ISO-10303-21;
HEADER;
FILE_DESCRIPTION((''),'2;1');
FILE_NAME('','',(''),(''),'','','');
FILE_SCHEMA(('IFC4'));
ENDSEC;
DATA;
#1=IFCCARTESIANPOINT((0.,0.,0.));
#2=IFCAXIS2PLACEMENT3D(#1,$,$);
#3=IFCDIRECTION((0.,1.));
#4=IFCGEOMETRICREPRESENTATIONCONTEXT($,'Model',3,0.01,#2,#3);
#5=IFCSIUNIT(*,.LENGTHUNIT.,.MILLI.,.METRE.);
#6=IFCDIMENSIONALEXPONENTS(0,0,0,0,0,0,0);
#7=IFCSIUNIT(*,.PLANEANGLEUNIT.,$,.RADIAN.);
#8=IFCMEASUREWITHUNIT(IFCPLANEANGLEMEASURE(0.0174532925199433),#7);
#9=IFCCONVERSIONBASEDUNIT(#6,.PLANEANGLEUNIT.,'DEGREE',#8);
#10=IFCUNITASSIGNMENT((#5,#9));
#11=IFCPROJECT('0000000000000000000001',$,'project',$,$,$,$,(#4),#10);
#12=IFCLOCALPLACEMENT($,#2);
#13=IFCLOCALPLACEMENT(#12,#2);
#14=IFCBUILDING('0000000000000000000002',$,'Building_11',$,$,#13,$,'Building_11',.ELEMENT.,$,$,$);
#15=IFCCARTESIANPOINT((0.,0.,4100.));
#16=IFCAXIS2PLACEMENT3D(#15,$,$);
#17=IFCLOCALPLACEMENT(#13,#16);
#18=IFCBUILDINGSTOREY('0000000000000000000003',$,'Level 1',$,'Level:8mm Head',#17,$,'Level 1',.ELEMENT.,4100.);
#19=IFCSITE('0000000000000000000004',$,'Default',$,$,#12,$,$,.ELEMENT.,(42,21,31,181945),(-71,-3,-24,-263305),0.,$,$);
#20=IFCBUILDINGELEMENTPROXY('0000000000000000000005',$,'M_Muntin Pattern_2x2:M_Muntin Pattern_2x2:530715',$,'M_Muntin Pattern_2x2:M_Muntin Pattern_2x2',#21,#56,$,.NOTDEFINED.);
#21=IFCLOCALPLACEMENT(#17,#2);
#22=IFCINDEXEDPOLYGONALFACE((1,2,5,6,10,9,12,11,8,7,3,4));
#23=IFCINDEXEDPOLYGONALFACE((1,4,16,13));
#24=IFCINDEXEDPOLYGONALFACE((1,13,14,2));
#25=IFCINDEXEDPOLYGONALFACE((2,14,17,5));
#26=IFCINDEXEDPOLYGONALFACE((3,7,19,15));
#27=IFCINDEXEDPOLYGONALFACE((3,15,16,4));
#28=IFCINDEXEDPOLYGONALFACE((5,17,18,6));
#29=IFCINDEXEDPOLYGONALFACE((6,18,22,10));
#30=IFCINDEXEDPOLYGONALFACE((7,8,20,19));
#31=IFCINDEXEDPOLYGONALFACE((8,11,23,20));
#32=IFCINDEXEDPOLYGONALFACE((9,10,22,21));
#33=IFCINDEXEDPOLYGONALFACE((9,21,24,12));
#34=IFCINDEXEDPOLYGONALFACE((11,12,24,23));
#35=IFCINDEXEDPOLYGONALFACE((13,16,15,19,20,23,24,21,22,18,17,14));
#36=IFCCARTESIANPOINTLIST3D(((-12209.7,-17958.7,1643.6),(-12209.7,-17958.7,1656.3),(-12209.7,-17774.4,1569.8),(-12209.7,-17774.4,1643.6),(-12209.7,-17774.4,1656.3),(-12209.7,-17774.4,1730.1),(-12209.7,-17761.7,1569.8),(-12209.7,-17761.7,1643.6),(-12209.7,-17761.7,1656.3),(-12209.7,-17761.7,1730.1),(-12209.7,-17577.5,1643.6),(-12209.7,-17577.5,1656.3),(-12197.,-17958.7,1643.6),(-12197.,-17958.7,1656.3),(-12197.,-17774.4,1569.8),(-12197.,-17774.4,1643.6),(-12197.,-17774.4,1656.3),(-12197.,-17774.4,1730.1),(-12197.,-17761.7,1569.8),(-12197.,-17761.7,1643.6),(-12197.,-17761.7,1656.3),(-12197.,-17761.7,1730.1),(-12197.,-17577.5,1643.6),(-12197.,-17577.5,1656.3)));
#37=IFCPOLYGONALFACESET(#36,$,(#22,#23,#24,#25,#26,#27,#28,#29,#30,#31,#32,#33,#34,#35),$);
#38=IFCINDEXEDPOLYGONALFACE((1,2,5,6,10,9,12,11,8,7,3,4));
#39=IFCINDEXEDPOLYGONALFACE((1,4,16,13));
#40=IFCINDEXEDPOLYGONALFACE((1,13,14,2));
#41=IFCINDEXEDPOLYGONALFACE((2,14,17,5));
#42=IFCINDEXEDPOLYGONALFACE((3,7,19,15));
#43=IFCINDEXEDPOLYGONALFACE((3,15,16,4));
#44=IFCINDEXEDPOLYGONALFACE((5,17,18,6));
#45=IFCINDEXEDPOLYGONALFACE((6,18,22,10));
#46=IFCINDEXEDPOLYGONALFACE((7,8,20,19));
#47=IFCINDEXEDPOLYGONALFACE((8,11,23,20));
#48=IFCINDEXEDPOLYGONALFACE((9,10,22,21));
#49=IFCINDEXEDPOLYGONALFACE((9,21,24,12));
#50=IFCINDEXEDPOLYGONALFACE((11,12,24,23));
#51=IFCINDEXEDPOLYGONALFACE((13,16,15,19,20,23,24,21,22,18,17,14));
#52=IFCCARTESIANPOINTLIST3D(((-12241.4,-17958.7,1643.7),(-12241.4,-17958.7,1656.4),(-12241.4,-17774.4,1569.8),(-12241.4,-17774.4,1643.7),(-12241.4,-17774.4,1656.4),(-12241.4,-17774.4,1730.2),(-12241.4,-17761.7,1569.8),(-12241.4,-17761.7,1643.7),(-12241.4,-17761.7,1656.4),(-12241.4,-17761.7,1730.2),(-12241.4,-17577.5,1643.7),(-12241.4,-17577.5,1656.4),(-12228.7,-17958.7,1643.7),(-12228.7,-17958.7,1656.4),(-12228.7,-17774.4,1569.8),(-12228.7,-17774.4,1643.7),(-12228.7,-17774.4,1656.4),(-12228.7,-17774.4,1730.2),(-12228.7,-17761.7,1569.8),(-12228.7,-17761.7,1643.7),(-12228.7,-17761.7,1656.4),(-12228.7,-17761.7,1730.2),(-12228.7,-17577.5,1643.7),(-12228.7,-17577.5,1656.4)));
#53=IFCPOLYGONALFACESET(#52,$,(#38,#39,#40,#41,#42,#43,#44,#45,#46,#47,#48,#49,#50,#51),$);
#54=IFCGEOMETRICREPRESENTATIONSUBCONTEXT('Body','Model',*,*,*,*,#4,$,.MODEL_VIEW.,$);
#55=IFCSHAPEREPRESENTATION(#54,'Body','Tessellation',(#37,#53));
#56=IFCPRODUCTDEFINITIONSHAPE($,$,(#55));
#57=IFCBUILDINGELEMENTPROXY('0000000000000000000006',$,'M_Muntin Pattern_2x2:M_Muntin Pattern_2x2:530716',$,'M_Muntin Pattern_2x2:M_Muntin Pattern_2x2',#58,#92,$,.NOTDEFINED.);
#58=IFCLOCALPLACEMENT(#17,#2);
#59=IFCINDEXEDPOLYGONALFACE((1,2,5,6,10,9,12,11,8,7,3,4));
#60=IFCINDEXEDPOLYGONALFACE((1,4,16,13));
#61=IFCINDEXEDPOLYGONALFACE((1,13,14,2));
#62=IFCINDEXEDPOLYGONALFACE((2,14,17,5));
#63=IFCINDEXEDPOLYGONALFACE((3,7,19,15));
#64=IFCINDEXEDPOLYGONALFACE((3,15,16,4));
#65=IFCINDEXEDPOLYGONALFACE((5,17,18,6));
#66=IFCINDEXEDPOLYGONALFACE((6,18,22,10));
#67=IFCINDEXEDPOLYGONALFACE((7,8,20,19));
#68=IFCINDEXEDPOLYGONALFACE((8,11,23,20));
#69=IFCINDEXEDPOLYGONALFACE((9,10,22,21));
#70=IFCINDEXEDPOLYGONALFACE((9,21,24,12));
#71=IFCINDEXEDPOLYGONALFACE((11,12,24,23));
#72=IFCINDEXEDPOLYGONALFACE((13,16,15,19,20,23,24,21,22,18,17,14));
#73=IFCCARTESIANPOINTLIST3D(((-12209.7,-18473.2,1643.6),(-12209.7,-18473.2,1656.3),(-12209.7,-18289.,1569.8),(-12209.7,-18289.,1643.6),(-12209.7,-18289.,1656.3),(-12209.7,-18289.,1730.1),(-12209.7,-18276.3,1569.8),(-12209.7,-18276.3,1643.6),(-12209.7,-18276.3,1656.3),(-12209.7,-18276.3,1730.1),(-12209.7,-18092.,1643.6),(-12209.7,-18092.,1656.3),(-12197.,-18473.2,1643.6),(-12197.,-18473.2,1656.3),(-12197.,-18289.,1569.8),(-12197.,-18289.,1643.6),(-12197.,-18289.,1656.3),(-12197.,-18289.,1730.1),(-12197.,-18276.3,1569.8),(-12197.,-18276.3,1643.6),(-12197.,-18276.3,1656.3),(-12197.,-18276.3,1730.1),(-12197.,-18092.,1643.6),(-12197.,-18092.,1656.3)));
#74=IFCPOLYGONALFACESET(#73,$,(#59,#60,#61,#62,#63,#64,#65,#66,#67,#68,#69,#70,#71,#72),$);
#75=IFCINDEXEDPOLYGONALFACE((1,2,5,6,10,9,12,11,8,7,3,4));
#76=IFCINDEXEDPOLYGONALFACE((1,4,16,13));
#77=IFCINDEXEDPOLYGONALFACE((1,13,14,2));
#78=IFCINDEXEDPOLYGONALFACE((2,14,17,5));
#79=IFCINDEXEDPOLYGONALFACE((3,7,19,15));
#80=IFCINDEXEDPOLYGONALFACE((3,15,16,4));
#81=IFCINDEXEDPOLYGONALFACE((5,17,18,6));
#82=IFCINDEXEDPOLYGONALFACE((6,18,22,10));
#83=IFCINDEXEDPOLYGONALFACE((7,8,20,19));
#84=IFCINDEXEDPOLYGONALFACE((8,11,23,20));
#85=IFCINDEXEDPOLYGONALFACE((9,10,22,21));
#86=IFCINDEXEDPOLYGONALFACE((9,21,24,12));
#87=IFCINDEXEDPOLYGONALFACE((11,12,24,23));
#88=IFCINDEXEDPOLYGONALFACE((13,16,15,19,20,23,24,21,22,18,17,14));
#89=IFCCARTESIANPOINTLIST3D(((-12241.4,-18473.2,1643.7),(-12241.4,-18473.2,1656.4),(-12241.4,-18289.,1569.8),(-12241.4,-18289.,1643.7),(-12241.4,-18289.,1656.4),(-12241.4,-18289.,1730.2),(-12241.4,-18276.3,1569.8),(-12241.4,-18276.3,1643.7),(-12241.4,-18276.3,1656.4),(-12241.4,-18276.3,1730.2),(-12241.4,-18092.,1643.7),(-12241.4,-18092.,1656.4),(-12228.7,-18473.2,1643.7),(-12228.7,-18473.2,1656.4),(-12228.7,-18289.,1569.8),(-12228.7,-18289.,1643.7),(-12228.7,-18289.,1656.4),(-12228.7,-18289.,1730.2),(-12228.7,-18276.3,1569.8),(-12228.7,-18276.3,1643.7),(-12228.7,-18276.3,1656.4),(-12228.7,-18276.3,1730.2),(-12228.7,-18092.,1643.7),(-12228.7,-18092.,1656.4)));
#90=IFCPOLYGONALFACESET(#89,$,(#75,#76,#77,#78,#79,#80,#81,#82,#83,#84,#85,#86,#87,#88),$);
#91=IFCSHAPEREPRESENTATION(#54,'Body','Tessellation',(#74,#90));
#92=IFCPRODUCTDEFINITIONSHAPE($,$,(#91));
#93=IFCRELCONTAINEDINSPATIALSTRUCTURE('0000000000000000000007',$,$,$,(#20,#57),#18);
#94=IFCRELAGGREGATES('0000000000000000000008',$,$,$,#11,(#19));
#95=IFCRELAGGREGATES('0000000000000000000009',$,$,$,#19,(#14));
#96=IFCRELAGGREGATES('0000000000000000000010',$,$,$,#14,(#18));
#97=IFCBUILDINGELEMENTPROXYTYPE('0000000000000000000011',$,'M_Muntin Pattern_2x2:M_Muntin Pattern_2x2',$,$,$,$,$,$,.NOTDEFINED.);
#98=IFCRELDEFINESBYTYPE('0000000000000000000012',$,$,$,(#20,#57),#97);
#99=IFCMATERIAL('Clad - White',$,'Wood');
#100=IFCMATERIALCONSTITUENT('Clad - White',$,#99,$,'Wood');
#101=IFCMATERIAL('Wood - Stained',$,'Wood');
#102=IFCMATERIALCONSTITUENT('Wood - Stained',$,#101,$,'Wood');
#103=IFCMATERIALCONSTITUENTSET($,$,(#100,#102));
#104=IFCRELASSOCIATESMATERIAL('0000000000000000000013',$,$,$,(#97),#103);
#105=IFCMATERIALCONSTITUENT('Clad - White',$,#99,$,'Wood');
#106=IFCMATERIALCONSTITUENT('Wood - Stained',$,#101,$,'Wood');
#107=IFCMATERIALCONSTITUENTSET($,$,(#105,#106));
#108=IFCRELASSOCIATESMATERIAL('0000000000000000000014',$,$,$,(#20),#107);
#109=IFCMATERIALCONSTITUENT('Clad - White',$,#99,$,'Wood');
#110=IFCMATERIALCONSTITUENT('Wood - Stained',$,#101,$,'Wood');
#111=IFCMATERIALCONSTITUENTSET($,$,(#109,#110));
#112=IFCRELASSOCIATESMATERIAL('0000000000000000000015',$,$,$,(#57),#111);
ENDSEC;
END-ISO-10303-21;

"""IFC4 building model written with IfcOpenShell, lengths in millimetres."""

from ifc_helpers import new_model, entity, si_unit, converted_unit, direction, frame, origin, place, context, subcontext, project, spatial, indexed_curve, outline, extrude, source, transform, mapped, material, constituent, constituent_set, type_object, type_shapes, element, save


model = new_model("IFC4")

# Units and contexts
model_context = context("Model", 3, precision=0.01, world=origin(), true_north=direction((0.0, 1.0)))
body_context = subcontext(model_context, "Body", "Model", "MODEL_VIEW")
ifc_project = project(units=[si_unit("LENGTHUNIT", "METRE", prefix="MILLI"), converted_unit("PLANEANGLEUNIT", "DEGREE", entity("IfcPlaneAngleMeasure", 0.0174532925199433), si_unit("PLANEANGLEUNIT", "RADIAN"), dimensions=[0, 0, 0, 0, 0, 0, 0])], contexts=[model_context])

# Site, building, storey
site_placement = place(None, origin())
site = spatial("IfcSite", under=ifc_project, at=site_placement, Name="Default", CompositionType="ELEMENT", RefLatitude=(42, 21, 31, 181945), RefLongitude=(-71, -3, -24, -263305), RefElevation=0.0)
building_placement = place(site_placement, origin())
building = spatial("IfcBuilding", under=site, at=building_placement, Name="Building_11", LongName="Building_11", CompositionType="ELEMENT")
storey_placement = place(building_placement, frame((0.0, 0.0, 4100.0)))
storey = spatial("IfcBuildingStorey", under=building, at=storey_placement, Name="Level 1", ObjectType="Level:8mm Head", LongName="Level 1", CompositionType="ELEMENT", Elevation=4100.0)

# Building element proxies
ifc_material_1 = material(Name="Clad - White", Category="Wood")
ifc_material_2 = material(Name="Wood - Stained", Category="Wood")
ifc_constituent_1 = constituent(ifc_material_1, Name="Clad - White", Category="Wood")
ifc_constituent_2 = constituent(ifc_material_2, Name="Wood - Stained", Category="Wood")
ifc_constituent_set_1 = constituent_set(constituents=[ifc_constituent_1, ifc_constituent_2])
ifc_constituent_3 = constituent(ifc_material_1, Name="Clad - White", Category="Wood")
ifc_constituent_4 = constituent(ifc_material_2, Name="Wood - Stained", Category="Wood")
ifc_constituent_set_2 = constituent_set(constituents=[ifc_constituent_3, ifc_constituent_4])
building_element_proxy_type_1 = type_object("IfcBuildingElementProxyType", Name="M_Muntin Pattern_2x2:M_Muntin Pattern_2x2", PredefinedType="NOTDEFINED", material=ifc_constituent_set_2)
shared_shape_1 = source(origin(), body_context, "Body", "SweptSolid", [
    extrude(outline(indexed_curve([(6.4, -6.4), (80.1, -6.4), (80.1, 6.3), (6.4, 6.3), (6.4, 190.6), (-6.3, 190.6), (-6.3, 6.3), (-80.2, 6.3), (-80.2, -6.4), (-6.3, -6.4), (-6.3, -190.6), (6.4, -190.6), (6.4, -6.4)], self_intersect=False)), frame((0.0, 9.5, 80.1), z_axis=(0.0, 1.0, 0.0), x_axis=(0.0, 0.0, 1.0)), (0.0, 0.0, 1.0), 12.7),
    extrude(outline(indexed_curve([(6.4, -6.4), (80.2, -6.4), (80.2, 6.3), (6.4, 6.3), (6.4, 190.6), (-6.3, 190.6), (-6.3, 6.3), (-80.2, 6.3), (-80.2, -6.4), (-6.3, -6.4), (-6.3, -190.6), (6.4, -190.6), (6.4, -6.4)], self_intersect=False)), frame((0.0, -22.2, 80.2), z_axis=(0.0, 1.0, 0.0), x_axis=(0.0, 0.0, 1.0)), (0.0, 0.0, 1.0), 12.7),
])
type_shapes(building_element_proxy_type_1, [shared_shape_1])
proxy_1_placement = place(storey_placement, frame((-12219.2, -17768.1, 1569.8), z_axis=(0.0, 0.0, 1.0), x_axis=(0.0, -1.0, 0.0)))
element("IfcBuildingElementProxy", 1, at=proxy_1_placement, inside=storey, type_object=building_element_proxy_type_1, material=ifc_constituent_set_1, Name="M_Muntin Pattern_2x2:M_Muntin Pattern_2x2:530715", ObjectType="M_Muntin Pattern_2x2:M_Muntin Pattern_2x2", PredefinedType="NOTDEFINED", context=body_context, shape_type="MappedRepresentation", body=[
    mapped(shared_shape_1, transform((0.0, 0.0, 0.0), scale=1.0)),
])
ifc_constituent_5 = constituent(ifc_material_1, Name="Clad - White", Category="Wood")
ifc_constituent_6 = constituent(ifc_material_2, Name="Wood - Stained", Category="Wood")
ifc_constituent_set_3 = constituent_set(constituents=[ifc_constituent_5, ifc_constituent_6])
proxy_2_placement = place(storey_placement, frame((-12219.2, -18282.6, 1569.8), z_axis=(0.0, 0.0, 1.0), x_axis=(0.0, -1.0, 0.0)))
element("IfcBuildingElementProxy", 2, at=proxy_2_placement, inside=storey, type_object=building_element_proxy_type_1, material=ifc_constituent_set_3, Name="M_Muntin Pattern_2x2:M_Muntin Pattern_2x2:530716", ObjectType="M_Muntin Pattern_2x2:M_Muntin Pattern_2x2", PredefinedType="NOTDEFINED", context=body_context, shape_type="MappedRepresentation", body=[
    mapped(shared_shape_1, transform((0.0, 0.0, 0.0), scale=1.0)),
])

save(model, "model.ifc")
